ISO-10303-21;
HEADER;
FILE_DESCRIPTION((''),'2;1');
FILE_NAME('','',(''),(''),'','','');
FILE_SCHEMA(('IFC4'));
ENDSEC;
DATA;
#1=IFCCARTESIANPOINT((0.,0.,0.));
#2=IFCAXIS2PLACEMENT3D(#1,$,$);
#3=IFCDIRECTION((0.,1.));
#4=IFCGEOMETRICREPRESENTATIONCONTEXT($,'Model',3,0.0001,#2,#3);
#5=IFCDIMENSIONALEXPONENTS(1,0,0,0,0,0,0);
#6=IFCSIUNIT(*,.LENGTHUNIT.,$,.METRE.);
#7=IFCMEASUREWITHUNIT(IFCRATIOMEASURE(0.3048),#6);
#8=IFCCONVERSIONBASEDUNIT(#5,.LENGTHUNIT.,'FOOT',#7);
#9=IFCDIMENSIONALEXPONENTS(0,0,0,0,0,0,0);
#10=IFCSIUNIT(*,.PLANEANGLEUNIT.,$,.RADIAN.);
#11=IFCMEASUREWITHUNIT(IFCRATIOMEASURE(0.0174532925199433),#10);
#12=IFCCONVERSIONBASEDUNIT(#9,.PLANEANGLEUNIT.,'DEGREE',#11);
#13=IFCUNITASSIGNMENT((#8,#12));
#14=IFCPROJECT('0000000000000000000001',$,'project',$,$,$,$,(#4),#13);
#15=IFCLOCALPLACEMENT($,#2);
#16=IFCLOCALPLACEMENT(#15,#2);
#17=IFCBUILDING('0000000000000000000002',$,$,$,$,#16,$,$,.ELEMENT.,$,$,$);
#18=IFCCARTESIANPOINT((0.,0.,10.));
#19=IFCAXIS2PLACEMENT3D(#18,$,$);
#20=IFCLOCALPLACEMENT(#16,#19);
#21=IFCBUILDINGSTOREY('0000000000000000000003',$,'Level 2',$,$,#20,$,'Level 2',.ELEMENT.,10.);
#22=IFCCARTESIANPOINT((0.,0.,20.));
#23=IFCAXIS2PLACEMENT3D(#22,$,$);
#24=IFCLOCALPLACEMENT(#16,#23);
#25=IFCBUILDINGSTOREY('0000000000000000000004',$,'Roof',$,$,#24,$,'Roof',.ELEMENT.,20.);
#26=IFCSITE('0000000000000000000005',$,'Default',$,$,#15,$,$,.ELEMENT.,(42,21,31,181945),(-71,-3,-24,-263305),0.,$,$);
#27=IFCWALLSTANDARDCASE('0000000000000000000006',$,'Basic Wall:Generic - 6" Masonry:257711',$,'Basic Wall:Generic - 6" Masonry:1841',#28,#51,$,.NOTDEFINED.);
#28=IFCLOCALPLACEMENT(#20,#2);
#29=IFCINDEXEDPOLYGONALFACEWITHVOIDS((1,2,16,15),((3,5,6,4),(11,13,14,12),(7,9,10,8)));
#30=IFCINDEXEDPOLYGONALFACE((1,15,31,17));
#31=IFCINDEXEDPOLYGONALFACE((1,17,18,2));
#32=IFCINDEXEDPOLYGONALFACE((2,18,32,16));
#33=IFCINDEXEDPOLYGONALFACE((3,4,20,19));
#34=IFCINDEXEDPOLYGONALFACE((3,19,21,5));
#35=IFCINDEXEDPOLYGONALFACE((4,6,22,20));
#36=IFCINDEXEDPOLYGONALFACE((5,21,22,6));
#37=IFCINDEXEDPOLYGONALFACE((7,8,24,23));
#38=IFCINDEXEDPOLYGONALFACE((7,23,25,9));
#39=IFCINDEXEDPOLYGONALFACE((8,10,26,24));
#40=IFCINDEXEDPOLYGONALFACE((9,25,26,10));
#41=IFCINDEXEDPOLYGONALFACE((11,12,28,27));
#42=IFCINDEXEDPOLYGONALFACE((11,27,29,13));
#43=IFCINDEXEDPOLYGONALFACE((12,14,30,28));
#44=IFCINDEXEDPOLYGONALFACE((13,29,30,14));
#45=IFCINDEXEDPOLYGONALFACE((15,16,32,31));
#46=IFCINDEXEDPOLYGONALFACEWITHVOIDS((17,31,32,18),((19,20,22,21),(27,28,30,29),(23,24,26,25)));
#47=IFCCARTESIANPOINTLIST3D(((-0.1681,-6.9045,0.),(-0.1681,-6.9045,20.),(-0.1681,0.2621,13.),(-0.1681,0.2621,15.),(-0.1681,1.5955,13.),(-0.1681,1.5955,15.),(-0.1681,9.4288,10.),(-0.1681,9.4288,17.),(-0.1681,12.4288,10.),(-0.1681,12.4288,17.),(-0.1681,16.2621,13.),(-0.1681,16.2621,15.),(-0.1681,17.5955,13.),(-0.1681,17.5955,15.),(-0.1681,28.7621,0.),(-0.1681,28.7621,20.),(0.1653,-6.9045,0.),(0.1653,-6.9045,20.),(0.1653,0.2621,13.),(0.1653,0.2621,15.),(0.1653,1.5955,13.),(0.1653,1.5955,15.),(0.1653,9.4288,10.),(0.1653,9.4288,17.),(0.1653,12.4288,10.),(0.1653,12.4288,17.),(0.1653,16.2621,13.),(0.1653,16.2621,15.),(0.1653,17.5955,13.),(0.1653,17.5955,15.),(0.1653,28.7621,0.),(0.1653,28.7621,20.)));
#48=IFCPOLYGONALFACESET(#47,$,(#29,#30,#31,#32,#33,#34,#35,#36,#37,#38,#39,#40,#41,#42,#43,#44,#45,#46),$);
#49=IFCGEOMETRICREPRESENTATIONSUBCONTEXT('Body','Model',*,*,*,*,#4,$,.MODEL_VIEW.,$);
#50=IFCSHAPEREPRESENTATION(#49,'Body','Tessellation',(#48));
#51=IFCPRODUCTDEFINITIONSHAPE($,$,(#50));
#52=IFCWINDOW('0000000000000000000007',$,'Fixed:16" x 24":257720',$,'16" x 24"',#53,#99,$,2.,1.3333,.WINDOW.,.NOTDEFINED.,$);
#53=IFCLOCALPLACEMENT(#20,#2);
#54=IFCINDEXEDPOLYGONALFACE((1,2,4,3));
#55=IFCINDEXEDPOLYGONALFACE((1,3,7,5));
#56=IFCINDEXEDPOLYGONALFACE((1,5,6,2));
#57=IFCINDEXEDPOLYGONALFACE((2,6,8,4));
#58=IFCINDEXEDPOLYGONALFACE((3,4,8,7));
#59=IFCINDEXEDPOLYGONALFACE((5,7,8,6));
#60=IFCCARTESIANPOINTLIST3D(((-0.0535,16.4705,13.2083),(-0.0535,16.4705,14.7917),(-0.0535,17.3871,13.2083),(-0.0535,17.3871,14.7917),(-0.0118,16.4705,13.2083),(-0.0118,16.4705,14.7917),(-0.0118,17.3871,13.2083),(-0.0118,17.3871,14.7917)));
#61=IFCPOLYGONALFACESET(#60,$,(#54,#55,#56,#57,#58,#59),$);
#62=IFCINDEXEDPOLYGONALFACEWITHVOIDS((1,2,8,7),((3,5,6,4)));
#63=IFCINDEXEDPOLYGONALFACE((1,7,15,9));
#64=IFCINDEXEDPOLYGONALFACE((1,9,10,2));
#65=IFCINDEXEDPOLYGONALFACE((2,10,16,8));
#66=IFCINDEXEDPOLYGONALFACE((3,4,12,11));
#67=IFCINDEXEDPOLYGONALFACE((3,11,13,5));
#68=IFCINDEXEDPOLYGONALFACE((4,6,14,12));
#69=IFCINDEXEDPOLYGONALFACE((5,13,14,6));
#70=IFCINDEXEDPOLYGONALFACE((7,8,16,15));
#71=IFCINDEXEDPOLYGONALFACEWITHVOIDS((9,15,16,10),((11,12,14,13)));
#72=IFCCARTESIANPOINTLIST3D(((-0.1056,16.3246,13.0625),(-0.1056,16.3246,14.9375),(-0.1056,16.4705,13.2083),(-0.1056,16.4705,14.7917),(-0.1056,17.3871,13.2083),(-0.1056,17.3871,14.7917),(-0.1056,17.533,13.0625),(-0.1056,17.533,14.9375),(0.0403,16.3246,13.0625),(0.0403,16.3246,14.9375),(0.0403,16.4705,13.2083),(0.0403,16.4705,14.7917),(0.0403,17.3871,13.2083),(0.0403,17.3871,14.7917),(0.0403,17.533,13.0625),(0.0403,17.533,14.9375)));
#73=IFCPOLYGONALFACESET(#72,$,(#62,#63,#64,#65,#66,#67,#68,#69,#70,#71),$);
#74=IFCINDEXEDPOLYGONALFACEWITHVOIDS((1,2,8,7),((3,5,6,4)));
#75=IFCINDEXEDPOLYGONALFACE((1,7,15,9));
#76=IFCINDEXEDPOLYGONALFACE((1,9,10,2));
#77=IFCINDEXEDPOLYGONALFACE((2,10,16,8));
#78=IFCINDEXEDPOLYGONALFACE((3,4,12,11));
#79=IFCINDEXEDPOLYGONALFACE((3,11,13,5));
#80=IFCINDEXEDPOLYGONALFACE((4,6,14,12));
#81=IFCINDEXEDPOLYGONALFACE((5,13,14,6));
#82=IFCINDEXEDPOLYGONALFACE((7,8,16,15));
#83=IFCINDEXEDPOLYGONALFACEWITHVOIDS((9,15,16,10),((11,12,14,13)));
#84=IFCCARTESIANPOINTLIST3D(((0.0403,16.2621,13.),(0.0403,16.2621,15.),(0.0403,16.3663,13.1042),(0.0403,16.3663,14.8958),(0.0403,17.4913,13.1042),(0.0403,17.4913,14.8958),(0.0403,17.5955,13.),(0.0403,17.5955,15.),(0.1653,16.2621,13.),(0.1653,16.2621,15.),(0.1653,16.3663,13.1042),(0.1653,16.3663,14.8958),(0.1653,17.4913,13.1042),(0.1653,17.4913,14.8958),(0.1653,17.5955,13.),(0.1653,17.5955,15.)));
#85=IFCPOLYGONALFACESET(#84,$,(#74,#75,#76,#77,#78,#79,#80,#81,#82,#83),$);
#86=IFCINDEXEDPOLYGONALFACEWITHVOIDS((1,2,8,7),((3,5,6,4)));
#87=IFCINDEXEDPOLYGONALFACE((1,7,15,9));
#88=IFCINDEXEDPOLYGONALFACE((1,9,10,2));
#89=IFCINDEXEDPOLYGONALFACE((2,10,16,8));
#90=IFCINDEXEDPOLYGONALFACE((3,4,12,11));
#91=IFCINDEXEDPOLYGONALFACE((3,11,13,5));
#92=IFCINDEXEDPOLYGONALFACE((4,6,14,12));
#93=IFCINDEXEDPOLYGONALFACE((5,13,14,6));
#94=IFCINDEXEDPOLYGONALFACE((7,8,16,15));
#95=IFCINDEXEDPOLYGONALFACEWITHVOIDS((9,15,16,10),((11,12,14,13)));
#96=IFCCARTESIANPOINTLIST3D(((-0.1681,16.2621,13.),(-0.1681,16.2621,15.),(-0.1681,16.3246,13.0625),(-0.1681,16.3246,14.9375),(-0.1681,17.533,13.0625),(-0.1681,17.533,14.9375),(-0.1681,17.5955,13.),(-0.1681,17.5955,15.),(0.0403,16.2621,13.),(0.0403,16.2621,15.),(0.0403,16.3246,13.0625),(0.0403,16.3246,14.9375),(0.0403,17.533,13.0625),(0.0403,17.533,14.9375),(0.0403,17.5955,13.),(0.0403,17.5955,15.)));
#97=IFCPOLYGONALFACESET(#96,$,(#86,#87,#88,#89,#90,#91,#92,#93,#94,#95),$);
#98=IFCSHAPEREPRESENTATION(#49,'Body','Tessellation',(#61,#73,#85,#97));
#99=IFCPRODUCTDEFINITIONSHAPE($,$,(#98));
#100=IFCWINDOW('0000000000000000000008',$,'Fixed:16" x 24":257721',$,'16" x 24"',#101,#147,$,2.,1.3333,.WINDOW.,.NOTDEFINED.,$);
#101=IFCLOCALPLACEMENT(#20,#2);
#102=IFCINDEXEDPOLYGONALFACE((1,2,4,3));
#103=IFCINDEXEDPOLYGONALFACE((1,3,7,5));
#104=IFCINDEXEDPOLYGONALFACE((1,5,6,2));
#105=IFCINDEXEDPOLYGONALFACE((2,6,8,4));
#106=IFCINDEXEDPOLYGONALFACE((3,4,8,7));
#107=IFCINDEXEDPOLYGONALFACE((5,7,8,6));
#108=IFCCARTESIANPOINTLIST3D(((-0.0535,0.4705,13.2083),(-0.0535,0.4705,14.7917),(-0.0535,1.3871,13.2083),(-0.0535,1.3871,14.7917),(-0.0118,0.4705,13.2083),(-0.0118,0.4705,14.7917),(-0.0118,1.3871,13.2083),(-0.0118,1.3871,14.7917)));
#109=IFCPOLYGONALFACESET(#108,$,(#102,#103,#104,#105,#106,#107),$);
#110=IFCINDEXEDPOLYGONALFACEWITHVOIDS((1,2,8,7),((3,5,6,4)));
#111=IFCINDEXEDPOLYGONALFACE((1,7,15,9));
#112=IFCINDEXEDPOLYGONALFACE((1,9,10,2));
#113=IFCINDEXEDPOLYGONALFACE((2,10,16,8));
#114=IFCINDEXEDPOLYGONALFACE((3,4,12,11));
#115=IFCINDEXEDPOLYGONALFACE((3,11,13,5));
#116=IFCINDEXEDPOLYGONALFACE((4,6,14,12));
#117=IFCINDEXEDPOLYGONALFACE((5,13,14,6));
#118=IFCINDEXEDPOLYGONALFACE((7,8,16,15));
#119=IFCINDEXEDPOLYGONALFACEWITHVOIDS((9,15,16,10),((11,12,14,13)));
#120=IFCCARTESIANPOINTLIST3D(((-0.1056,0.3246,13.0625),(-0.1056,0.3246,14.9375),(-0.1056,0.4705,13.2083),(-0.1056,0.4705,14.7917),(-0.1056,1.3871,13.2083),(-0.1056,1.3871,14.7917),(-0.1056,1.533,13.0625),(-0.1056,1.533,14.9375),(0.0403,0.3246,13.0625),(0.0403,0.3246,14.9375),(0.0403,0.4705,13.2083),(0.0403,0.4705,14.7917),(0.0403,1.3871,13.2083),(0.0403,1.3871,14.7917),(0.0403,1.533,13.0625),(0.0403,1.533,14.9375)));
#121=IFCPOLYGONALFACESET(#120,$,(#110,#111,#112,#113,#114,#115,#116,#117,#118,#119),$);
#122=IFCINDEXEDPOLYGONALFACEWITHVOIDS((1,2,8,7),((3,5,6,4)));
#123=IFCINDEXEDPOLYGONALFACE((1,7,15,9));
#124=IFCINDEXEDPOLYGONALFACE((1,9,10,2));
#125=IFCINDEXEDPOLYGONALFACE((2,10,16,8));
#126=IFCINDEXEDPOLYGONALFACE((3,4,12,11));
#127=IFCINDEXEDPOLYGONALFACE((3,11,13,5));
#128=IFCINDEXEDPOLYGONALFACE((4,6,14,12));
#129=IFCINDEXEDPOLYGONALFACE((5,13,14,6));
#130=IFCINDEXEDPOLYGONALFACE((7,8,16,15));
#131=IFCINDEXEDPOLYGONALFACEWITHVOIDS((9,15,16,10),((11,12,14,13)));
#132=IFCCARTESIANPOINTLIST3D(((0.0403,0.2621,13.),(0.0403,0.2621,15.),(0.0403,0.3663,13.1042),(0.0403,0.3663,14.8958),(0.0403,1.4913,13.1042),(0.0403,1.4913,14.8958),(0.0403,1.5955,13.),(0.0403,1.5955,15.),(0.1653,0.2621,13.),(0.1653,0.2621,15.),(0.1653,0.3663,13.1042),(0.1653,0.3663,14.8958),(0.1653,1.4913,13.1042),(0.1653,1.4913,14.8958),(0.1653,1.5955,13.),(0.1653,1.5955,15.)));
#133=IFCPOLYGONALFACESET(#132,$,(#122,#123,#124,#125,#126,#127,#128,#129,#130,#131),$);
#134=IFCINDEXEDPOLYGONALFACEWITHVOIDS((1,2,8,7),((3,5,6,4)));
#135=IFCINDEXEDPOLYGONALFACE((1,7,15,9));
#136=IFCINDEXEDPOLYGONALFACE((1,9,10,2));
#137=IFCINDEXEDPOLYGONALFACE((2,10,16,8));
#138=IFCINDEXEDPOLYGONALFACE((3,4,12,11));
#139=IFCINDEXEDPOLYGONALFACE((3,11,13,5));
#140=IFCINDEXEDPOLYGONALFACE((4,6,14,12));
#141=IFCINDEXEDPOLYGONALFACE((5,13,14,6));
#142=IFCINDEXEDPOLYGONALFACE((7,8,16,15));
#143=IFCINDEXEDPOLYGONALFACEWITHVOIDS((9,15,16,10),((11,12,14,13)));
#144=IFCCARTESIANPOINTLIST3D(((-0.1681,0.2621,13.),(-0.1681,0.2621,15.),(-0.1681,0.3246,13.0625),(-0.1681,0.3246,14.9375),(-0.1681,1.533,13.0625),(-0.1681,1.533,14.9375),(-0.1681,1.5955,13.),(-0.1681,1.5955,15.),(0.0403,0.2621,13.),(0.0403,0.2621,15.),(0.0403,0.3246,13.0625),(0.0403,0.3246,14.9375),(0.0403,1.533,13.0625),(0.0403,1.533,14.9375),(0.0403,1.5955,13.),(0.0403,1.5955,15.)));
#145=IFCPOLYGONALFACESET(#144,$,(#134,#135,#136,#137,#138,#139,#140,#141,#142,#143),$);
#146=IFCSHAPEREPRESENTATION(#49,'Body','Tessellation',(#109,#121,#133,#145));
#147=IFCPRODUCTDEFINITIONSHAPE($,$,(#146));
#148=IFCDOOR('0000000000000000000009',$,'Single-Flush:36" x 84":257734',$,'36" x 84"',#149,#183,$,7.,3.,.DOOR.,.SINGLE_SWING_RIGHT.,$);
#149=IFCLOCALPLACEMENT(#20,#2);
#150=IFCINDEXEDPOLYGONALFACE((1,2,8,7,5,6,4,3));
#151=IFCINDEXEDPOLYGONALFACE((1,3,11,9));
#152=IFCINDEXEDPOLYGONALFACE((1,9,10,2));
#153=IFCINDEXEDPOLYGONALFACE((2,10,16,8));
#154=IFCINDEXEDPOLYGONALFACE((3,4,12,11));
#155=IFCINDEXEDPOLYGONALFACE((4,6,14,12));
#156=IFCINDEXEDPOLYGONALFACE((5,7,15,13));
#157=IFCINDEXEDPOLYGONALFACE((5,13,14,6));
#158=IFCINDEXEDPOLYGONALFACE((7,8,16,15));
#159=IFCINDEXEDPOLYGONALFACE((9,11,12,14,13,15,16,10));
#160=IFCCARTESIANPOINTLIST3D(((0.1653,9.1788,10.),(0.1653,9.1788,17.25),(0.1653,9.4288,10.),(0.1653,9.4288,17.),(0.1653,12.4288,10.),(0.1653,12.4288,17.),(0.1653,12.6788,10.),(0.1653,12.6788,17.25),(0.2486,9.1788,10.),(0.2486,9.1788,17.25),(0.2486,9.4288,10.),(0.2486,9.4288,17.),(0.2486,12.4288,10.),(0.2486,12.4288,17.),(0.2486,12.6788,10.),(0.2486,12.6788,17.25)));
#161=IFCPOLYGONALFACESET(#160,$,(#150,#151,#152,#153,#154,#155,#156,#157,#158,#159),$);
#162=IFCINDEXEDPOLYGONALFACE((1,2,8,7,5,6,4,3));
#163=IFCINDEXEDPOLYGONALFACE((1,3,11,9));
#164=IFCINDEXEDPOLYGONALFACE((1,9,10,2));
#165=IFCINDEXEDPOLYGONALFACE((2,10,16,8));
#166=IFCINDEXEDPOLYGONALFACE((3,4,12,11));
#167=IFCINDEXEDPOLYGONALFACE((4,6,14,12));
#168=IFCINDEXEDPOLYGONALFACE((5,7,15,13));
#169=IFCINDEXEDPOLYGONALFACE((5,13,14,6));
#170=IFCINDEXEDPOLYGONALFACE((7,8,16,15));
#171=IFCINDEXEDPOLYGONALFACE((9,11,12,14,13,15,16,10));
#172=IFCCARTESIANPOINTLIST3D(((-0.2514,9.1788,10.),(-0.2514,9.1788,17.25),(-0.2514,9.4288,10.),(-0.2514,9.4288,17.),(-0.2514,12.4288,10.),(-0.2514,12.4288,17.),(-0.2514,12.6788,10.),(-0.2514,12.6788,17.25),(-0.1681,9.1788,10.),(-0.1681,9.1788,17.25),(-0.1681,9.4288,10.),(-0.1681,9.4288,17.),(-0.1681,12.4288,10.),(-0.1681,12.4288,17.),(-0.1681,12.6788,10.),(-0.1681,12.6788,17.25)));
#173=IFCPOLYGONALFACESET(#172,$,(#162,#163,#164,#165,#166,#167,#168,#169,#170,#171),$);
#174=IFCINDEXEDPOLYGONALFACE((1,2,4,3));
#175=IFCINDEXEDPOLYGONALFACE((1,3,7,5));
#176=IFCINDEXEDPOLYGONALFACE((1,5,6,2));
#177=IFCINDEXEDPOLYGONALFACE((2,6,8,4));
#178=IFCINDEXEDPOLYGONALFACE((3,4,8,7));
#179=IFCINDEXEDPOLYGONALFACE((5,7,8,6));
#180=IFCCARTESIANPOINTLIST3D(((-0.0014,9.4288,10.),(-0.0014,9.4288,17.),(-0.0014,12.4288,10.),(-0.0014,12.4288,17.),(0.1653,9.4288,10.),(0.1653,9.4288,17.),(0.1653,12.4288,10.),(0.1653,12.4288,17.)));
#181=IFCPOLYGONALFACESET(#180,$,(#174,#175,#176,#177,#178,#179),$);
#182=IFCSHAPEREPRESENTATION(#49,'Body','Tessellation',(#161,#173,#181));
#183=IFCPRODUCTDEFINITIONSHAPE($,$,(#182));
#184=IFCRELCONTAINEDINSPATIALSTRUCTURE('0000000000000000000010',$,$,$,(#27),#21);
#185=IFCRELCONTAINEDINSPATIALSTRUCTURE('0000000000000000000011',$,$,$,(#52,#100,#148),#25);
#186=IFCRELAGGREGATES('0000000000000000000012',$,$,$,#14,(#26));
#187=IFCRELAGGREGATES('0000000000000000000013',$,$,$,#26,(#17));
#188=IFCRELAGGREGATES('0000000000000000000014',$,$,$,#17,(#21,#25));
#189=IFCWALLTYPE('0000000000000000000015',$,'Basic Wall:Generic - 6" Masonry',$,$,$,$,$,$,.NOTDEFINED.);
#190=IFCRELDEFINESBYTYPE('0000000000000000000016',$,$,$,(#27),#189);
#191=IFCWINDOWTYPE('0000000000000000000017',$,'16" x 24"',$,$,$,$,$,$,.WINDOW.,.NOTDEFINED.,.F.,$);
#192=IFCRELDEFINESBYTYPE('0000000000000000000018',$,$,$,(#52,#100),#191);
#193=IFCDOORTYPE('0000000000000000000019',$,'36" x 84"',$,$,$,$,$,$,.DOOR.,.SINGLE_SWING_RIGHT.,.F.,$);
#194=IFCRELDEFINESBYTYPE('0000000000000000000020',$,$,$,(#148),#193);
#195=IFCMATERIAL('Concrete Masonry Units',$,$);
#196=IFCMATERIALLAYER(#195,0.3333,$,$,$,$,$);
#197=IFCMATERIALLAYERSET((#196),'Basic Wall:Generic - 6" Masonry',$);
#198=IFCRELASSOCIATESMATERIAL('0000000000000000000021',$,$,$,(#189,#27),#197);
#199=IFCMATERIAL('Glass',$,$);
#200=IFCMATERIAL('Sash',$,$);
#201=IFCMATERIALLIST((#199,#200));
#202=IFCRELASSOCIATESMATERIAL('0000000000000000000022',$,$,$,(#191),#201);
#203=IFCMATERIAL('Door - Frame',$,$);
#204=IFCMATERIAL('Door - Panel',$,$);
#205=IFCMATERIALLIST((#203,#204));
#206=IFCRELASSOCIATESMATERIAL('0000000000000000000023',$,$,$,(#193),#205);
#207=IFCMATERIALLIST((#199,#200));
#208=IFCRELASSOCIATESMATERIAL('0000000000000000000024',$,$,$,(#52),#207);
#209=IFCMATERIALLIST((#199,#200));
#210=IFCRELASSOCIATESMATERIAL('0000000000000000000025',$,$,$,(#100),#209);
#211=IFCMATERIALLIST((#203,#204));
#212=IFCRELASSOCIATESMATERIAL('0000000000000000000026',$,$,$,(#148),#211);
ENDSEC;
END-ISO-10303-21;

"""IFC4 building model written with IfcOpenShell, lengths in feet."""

from ifc_helpers import new_model, entity, si_unit, converted_unit, direction, frame, frame_2d, origin, origin_2d_with_axis, place, context, subcontext, project, spatial, polyline, rectangle, outline, extrude, source, transform, mapped, material, material_list, layer, layer_set, layer_usage, type_object, type_shapes, element, fill, save


model = new_model("IFC4")

# Units and contexts
model_context = context("Model", 3, precision=0.0001, world=origin(), true_north=direction((0.0, 1.0)))
body_context = subcontext(model_context, "Body", "Model", "MODEL_VIEW")
ifc_project = project(units=[converted_unit("LENGTHUNIT", "FOOT", entity("IfcRatioMeasure", 0.3048), si_unit("LENGTHUNIT", "METRE"), dimensions=[1, 0, 0, 0, 0, 0, 0]), converted_unit("PLANEANGLEUNIT", "DEGREE", entity("IfcRatioMeasure", 0.0174532925199433), si_unit("PLANEANGLEUNIT", "RADIAN"), dimensions=[0, 0, 0, 0, 0, 0, 0])], contexts=[model_context])

# Site, building, storey
site_placement = place(None, origin())
site = spatial("IfcSite", under=ifc_project, at=site_placement, Name="Default", CompositionType="ELEMENT", RefLatitude=(42, 21, 31, 181945), RefLongitude=(-71, -3, -24, -263305), RefElevation=0.0)
building_placement = place(site_placement, origin())
building = spatial("IfcBuilding", under=site, at=building_placement, CompositionType="ELEMENT")
storey_1_placement = place(building_placement, frame((0.0, 0.0, 10.0)))
storey_1 = spatial("IfcBuildingStorey", under=building, at=storey_1_placement, Name="Level 2", LongName="Level 2", CompositionType="ELEMENT", Elevation=10.0)

# Shared definitions
ifc_material_1 = material(Name="Concrete Masonry Units")
ifc_layer = layer(ifc_material_1, 0.3333)
ifc_layer_set = layer_set([ifc_layer], Name="Basic Wall:Generic - 6\" Masonry")
wall_type = type_object("IfcWallType", Name="Basic Wall:Generic - 6\" Masonry", PredefinedType="NOTDEFINED", material=ifc_layer_set)

# Shared definitions
storey_2_placement = place(building_placement, frame((0.0, 0.0, 20.0)))
storey_2 = spatial("IfcBuildingStorey", under=building, at=storey_2_placement, Name="Roof", LongName="Roof", CompositionType="ELEMENT", Elevation=20.0)

# Shared definitions
ifc_material_2 = material(Name="Glass")
ifc_material_3 = material(Name="Sash")
ifc_material_list_1 = material_list([ifc_material_2, ifc_material_3])
window_type = type_object("IfcWindowType", Name="16\" x 24\"", ParameterTakesPrecedence=False, PartitioningType="NOTDEFINED", PredefinedType="WINDOW", material=ifc_material_list_1)
shared_shape_1 = source(origin(), body_context, "Body", "SweptSolid", [
    extrude(rectangle(XDim=0.0417, YDim=0.9167, at=origin_2d_with_axis()), frame((0.6667, 0.1979, 0.2083), z_axis=(0.0, 0.0, 1.0), x_axis=(0.0, 1.0, 0.0)), (0.0, 0.0, 1.0), 1.5833),
    extrude(outline(polyline([(-0.6042, -0.9375), (0.6042, -0.9375), (0.6042, 0.9375), (-0.6042, 0.9375), (-0.6042, -0.9375)]), holes=[polyline([(-0.4583, -0.7917), (-0.4583, 0.7917), (0.4583, 0.7917), (0.4583, -0.7917), (-0.4583, -0.7917)])]), frame((0.6667, 0.125, 1.0), z_axis=(0.0, 1.0, 0.0), x_axis=(1.0, 0.0, 0.0)), (0.0, 0.0, 1.0), 0.1458),
    extrude(outline(polyline([(-0.6667, -1.0), (0.6667, -1.0), (0.6667, 1.0), (-0.6667, 1.0), (-0.6667, -1.0)]), holes=[polyline([(-0.5625, -0.8958), (-0.5625, 0.8958), (0.5625, 0.8958), (0.5625, -0.8958), (-0.5625, -0.8958)])]), frame((0.6667, 0.0, 1.0), z_axis=(0.0, 1.0, 0.0), x_axis=(1.0, 0.0, 0.0)), (0.0, 0.0, 1.0), 0.125),
    extrude(outline(polyline([(-1.0, -0.6667), (1.0, -0.6667), (1.0, 0.6667), (-1.0, 0.6667), (-1.0, -0.6667)]), holes=[polyline([(-0.9375, -0.6042), (-0.9375, 0.6042), (0.9375, 0.6042), (0.9375, -0.6042), (-0.9375, -0.6042)])]), frame((0.6667, 0.125, 1.0), z_axis=(0.0, 1.0, 0.0), x_axis=(0.0, 0.0, -1.0)), (0.0, 0.0, 1.0), 0.2083),
])
type_shapes(window_type, [shared_shape_1])

# Shared definitions
ifc_material_4 = material(Name="Door - Frame")
ifc_material_5 = material(Name="Door - Panel")
ifc_material_list_2 = material_list([ifc_material_4, ifc_material_5])
door_type = type_object("IfcDoorType", Name="36\" x 84\"", OperationType="SINGLE_SWING_RIGHT", ParameterTakesPrecedence=False, PredefinedType="DOOR", material=ifc_material_list_2)
shared_shape_2 = source(origin(), body_context, "Body", "SweptSolid", [
    extrude(outline(polyline([(-1.75, -3.6875), (1.75, -3.6875), (1.75, 3.5625), (1.5, 3.5625), (1.5, -3.4375), (-1.5, -3.4375), (-1.5, 3.5625), (-1.75, 3.5625), (-1.75, -3.6875)])), frame((1.5, 0.3333, 3.5625), z_axis=(0.0, 1.0, 0.0), x_axis=(1.0, 0.0, 0.0)), (0.0, 0.0, 1.0), 0.0833),
    extrude(outline(polyline([(-3.6875, -1.75), (3.5625, -1.75), (3.5625, -1.5), (-3.4375, -1.5), (-3.4375, 1.5), (3.5625, 1.5), (3.5625, 1.75), (-3.6875, 1.75), (-3.6875, -1.75)])), frame((1.5, -0.0833, 3.5625), z_axis=(0.0, 1.0, 0.0), x_axis=(0.0, 0.0, -1.0)), (0.0, 0.0, 1.0), 0.0833),
    extrude(rectangle(XDim=0.1667, YDim=3.0, at=frame_2d((0.0, 0.0), x_axis=(1.0, 0.0))), frame((1.5, 0.25, 0.0), z_axis=(0.0, 0.0, 1.0), x_axis=(0.0, 1.0, 0.0)), (0.0, 0.0, 1.0), 7.0),
])
type_shapes(door_type, [shared_shape_2])

# Wall, openings, windows, door
ifc_layer_usage_1 = layer_usage(ifc_layer_set, "AXIS2", "NEGATIVE", 0.1667)
wall_1_placement = place(storey_1_placement, frame((-0.0014, -6.9045, 0.0), z_axis=(0.0, 0.0, 1.0), x_axis=(0.0, 1.0, 0.0)))
wall_1 = element("IfcWallStandardCase", 1, at=wall_1_placement, inside=storey_1, type_object=wall_type, material=ifc_layer_usage_1, Name="Basic Wall:Generic - 6\" Masonry:257711", ObjectType="Basic Wall:Generic - 6\" Masonry:1841", PredefinedType="NOTDEFINED", context=body_context, shape_type="SweptSolid", body=[
    extrude(rectangle(XDim=35.6667, YDim=0.3333, at=frame_2d((17.8333, 0.0), x_axis=(-1.0, 0.0))), origin(), (0.0, 0.0, 1.0), 20.0),
])
opening_1_placement = place(wall_1_placement, frame((19.3333, 0.1667, 10.0)))
opening_1 = element("IfcOpeningElement", 2, at=opening_1_placement, cuts=wall_1, ObjectType="Opening", PredefinedType="OPENING", context=body_context, shape_type="SweptSolid", body=[
    extrude(rectangle(XDim=3.0, YDim=7.0, at=frame_2d((3.5, 1.5), x_axis=(0.0, 1.0))), frame((0.0, 0.0, 0.0), z_axis=(0.0, -1.0, 0.0), x_axis=(0.0, 0.0, 1.0)), (0.0, 0.0, 1.0), 0.3333),
])
opening_2_placement = place(wall_1_placement, frame((23.1667, -0.1667, 13.0)))
opening_2 = element("IfcOpeningElement", 3, at=opening_2_placement, cuts=wall_1, ObjectType="Opening", PredefinedType="OPENING", context=body_context, shape_type="SweptSolid", body=[
    extrude(rectangle(XDim=2.0, YDim=1.3333, at=frame_2d((1.0, 0.6667), x_axis=(-1.0, 0.0))), frame((0.0, 0.0, 0.0), z_axis=(0.0, 1.0, 0.0), x_axis=(0.0, 0.0, 1.0)), (0.0, 0.0, 1.0), 0.3333),
])
opening_3_placement = place(wall_1_placement, frame((7.1667, -0.1667, 13.0)))
opening_3 = element("IfcOpeningElement", 4, at=opening_3_placement, cuts=wall_1, ObjectType="Opening", PredefinedType="OPENING", context=body_context, shape_type="SweptSolid", body=[
    extrude(rectangle(XDim=2.0, YDim=1.3333, at=frame_2d((1.0, 0.6667), x_axis=(-1.0, 0.0))), frame((0.0, 0.0, 0.0), z_axis=(0.0, 1.0, 0.0), x_axis=(0.0, 0.0, 1.0)), (0.0, 0.0, 1.0), 0.3333),
])
ifc_material_list_3 = material_list([ifc_material_2, ifc_material_3])
window_1_placement = place(opening_2_placement, origin())
window_1 = element("IfcWindow", 5, at=window_1_placement, inside=storey_2, type_object=window_type, material=ifc_material_list_3, Name="Fixed:16\" x 24\":257720", ObjectType="16\" x 24\"", OverallHeight=2.0, OverallWidth=1.3333, PartitioningType="NOTDEFINED", PredefinedType="WINDOW", context=body_context, shape_type="MappedRepresentation", body=[
    mapped(shared_shape_1, transform((0.0, 0.0, 0.0), scale=1.0)),
])
fill(opening_2, window_1)
ifc_material_list_4 = material_list([ifc_material_2, ifc_material_3])
window_2_placement = place(opening_3_placement, origin())
window_2 = element("IfcWindow", 6, at=window_2_placement, inside=storey_2, type_object=window_type, material=ifc_material_list_4, Name="Fixed:16\" x 24\":257721", ObjectType="16\" x 24\"", OverallHeight=2.0, OverallWidth=1.3333, PartitioningType="NOTDEFINED", PredefinedType="WINDOW", context=body_context, shape_type="MappedRepresentation", body=[
    mapped(shared_shape_1, transform((0.0, 0.0, 0.0), scale=1.0)),
])
fill(opening_3, window_2)
ifc_material_list_5 = material_list([ifc_material_4, ifc_material_5])
door_1_placement = place(opening_1_placement, frame((0.0, 0.0, 0.0), z_axis=(0.0, 0.0, 1.0), x_axis=(-1.0, 0.0, 0.0)))
door_1 = element("IfcDoor", 7, at=door_1_placement, inside=storey_2, type_object=door_type, material=ifc_material_list_5, Name="Single-Flush:36\" x 84\":257734", ObjectType="36\" x 84\"", OperationType="SINGLE_SWING_RIGHT", OverallHeight=7.0, OverallWidth=3.0, PredefinedType="DOOR", context=body_context, shape_type="MappedRepresentation", body=[
    mapped(shared_shape_2, transform((0.0, 0.0, 0.0), scale=1.0)),
])
fill(opening_1, door_1)

save(model, "model.ifc")
